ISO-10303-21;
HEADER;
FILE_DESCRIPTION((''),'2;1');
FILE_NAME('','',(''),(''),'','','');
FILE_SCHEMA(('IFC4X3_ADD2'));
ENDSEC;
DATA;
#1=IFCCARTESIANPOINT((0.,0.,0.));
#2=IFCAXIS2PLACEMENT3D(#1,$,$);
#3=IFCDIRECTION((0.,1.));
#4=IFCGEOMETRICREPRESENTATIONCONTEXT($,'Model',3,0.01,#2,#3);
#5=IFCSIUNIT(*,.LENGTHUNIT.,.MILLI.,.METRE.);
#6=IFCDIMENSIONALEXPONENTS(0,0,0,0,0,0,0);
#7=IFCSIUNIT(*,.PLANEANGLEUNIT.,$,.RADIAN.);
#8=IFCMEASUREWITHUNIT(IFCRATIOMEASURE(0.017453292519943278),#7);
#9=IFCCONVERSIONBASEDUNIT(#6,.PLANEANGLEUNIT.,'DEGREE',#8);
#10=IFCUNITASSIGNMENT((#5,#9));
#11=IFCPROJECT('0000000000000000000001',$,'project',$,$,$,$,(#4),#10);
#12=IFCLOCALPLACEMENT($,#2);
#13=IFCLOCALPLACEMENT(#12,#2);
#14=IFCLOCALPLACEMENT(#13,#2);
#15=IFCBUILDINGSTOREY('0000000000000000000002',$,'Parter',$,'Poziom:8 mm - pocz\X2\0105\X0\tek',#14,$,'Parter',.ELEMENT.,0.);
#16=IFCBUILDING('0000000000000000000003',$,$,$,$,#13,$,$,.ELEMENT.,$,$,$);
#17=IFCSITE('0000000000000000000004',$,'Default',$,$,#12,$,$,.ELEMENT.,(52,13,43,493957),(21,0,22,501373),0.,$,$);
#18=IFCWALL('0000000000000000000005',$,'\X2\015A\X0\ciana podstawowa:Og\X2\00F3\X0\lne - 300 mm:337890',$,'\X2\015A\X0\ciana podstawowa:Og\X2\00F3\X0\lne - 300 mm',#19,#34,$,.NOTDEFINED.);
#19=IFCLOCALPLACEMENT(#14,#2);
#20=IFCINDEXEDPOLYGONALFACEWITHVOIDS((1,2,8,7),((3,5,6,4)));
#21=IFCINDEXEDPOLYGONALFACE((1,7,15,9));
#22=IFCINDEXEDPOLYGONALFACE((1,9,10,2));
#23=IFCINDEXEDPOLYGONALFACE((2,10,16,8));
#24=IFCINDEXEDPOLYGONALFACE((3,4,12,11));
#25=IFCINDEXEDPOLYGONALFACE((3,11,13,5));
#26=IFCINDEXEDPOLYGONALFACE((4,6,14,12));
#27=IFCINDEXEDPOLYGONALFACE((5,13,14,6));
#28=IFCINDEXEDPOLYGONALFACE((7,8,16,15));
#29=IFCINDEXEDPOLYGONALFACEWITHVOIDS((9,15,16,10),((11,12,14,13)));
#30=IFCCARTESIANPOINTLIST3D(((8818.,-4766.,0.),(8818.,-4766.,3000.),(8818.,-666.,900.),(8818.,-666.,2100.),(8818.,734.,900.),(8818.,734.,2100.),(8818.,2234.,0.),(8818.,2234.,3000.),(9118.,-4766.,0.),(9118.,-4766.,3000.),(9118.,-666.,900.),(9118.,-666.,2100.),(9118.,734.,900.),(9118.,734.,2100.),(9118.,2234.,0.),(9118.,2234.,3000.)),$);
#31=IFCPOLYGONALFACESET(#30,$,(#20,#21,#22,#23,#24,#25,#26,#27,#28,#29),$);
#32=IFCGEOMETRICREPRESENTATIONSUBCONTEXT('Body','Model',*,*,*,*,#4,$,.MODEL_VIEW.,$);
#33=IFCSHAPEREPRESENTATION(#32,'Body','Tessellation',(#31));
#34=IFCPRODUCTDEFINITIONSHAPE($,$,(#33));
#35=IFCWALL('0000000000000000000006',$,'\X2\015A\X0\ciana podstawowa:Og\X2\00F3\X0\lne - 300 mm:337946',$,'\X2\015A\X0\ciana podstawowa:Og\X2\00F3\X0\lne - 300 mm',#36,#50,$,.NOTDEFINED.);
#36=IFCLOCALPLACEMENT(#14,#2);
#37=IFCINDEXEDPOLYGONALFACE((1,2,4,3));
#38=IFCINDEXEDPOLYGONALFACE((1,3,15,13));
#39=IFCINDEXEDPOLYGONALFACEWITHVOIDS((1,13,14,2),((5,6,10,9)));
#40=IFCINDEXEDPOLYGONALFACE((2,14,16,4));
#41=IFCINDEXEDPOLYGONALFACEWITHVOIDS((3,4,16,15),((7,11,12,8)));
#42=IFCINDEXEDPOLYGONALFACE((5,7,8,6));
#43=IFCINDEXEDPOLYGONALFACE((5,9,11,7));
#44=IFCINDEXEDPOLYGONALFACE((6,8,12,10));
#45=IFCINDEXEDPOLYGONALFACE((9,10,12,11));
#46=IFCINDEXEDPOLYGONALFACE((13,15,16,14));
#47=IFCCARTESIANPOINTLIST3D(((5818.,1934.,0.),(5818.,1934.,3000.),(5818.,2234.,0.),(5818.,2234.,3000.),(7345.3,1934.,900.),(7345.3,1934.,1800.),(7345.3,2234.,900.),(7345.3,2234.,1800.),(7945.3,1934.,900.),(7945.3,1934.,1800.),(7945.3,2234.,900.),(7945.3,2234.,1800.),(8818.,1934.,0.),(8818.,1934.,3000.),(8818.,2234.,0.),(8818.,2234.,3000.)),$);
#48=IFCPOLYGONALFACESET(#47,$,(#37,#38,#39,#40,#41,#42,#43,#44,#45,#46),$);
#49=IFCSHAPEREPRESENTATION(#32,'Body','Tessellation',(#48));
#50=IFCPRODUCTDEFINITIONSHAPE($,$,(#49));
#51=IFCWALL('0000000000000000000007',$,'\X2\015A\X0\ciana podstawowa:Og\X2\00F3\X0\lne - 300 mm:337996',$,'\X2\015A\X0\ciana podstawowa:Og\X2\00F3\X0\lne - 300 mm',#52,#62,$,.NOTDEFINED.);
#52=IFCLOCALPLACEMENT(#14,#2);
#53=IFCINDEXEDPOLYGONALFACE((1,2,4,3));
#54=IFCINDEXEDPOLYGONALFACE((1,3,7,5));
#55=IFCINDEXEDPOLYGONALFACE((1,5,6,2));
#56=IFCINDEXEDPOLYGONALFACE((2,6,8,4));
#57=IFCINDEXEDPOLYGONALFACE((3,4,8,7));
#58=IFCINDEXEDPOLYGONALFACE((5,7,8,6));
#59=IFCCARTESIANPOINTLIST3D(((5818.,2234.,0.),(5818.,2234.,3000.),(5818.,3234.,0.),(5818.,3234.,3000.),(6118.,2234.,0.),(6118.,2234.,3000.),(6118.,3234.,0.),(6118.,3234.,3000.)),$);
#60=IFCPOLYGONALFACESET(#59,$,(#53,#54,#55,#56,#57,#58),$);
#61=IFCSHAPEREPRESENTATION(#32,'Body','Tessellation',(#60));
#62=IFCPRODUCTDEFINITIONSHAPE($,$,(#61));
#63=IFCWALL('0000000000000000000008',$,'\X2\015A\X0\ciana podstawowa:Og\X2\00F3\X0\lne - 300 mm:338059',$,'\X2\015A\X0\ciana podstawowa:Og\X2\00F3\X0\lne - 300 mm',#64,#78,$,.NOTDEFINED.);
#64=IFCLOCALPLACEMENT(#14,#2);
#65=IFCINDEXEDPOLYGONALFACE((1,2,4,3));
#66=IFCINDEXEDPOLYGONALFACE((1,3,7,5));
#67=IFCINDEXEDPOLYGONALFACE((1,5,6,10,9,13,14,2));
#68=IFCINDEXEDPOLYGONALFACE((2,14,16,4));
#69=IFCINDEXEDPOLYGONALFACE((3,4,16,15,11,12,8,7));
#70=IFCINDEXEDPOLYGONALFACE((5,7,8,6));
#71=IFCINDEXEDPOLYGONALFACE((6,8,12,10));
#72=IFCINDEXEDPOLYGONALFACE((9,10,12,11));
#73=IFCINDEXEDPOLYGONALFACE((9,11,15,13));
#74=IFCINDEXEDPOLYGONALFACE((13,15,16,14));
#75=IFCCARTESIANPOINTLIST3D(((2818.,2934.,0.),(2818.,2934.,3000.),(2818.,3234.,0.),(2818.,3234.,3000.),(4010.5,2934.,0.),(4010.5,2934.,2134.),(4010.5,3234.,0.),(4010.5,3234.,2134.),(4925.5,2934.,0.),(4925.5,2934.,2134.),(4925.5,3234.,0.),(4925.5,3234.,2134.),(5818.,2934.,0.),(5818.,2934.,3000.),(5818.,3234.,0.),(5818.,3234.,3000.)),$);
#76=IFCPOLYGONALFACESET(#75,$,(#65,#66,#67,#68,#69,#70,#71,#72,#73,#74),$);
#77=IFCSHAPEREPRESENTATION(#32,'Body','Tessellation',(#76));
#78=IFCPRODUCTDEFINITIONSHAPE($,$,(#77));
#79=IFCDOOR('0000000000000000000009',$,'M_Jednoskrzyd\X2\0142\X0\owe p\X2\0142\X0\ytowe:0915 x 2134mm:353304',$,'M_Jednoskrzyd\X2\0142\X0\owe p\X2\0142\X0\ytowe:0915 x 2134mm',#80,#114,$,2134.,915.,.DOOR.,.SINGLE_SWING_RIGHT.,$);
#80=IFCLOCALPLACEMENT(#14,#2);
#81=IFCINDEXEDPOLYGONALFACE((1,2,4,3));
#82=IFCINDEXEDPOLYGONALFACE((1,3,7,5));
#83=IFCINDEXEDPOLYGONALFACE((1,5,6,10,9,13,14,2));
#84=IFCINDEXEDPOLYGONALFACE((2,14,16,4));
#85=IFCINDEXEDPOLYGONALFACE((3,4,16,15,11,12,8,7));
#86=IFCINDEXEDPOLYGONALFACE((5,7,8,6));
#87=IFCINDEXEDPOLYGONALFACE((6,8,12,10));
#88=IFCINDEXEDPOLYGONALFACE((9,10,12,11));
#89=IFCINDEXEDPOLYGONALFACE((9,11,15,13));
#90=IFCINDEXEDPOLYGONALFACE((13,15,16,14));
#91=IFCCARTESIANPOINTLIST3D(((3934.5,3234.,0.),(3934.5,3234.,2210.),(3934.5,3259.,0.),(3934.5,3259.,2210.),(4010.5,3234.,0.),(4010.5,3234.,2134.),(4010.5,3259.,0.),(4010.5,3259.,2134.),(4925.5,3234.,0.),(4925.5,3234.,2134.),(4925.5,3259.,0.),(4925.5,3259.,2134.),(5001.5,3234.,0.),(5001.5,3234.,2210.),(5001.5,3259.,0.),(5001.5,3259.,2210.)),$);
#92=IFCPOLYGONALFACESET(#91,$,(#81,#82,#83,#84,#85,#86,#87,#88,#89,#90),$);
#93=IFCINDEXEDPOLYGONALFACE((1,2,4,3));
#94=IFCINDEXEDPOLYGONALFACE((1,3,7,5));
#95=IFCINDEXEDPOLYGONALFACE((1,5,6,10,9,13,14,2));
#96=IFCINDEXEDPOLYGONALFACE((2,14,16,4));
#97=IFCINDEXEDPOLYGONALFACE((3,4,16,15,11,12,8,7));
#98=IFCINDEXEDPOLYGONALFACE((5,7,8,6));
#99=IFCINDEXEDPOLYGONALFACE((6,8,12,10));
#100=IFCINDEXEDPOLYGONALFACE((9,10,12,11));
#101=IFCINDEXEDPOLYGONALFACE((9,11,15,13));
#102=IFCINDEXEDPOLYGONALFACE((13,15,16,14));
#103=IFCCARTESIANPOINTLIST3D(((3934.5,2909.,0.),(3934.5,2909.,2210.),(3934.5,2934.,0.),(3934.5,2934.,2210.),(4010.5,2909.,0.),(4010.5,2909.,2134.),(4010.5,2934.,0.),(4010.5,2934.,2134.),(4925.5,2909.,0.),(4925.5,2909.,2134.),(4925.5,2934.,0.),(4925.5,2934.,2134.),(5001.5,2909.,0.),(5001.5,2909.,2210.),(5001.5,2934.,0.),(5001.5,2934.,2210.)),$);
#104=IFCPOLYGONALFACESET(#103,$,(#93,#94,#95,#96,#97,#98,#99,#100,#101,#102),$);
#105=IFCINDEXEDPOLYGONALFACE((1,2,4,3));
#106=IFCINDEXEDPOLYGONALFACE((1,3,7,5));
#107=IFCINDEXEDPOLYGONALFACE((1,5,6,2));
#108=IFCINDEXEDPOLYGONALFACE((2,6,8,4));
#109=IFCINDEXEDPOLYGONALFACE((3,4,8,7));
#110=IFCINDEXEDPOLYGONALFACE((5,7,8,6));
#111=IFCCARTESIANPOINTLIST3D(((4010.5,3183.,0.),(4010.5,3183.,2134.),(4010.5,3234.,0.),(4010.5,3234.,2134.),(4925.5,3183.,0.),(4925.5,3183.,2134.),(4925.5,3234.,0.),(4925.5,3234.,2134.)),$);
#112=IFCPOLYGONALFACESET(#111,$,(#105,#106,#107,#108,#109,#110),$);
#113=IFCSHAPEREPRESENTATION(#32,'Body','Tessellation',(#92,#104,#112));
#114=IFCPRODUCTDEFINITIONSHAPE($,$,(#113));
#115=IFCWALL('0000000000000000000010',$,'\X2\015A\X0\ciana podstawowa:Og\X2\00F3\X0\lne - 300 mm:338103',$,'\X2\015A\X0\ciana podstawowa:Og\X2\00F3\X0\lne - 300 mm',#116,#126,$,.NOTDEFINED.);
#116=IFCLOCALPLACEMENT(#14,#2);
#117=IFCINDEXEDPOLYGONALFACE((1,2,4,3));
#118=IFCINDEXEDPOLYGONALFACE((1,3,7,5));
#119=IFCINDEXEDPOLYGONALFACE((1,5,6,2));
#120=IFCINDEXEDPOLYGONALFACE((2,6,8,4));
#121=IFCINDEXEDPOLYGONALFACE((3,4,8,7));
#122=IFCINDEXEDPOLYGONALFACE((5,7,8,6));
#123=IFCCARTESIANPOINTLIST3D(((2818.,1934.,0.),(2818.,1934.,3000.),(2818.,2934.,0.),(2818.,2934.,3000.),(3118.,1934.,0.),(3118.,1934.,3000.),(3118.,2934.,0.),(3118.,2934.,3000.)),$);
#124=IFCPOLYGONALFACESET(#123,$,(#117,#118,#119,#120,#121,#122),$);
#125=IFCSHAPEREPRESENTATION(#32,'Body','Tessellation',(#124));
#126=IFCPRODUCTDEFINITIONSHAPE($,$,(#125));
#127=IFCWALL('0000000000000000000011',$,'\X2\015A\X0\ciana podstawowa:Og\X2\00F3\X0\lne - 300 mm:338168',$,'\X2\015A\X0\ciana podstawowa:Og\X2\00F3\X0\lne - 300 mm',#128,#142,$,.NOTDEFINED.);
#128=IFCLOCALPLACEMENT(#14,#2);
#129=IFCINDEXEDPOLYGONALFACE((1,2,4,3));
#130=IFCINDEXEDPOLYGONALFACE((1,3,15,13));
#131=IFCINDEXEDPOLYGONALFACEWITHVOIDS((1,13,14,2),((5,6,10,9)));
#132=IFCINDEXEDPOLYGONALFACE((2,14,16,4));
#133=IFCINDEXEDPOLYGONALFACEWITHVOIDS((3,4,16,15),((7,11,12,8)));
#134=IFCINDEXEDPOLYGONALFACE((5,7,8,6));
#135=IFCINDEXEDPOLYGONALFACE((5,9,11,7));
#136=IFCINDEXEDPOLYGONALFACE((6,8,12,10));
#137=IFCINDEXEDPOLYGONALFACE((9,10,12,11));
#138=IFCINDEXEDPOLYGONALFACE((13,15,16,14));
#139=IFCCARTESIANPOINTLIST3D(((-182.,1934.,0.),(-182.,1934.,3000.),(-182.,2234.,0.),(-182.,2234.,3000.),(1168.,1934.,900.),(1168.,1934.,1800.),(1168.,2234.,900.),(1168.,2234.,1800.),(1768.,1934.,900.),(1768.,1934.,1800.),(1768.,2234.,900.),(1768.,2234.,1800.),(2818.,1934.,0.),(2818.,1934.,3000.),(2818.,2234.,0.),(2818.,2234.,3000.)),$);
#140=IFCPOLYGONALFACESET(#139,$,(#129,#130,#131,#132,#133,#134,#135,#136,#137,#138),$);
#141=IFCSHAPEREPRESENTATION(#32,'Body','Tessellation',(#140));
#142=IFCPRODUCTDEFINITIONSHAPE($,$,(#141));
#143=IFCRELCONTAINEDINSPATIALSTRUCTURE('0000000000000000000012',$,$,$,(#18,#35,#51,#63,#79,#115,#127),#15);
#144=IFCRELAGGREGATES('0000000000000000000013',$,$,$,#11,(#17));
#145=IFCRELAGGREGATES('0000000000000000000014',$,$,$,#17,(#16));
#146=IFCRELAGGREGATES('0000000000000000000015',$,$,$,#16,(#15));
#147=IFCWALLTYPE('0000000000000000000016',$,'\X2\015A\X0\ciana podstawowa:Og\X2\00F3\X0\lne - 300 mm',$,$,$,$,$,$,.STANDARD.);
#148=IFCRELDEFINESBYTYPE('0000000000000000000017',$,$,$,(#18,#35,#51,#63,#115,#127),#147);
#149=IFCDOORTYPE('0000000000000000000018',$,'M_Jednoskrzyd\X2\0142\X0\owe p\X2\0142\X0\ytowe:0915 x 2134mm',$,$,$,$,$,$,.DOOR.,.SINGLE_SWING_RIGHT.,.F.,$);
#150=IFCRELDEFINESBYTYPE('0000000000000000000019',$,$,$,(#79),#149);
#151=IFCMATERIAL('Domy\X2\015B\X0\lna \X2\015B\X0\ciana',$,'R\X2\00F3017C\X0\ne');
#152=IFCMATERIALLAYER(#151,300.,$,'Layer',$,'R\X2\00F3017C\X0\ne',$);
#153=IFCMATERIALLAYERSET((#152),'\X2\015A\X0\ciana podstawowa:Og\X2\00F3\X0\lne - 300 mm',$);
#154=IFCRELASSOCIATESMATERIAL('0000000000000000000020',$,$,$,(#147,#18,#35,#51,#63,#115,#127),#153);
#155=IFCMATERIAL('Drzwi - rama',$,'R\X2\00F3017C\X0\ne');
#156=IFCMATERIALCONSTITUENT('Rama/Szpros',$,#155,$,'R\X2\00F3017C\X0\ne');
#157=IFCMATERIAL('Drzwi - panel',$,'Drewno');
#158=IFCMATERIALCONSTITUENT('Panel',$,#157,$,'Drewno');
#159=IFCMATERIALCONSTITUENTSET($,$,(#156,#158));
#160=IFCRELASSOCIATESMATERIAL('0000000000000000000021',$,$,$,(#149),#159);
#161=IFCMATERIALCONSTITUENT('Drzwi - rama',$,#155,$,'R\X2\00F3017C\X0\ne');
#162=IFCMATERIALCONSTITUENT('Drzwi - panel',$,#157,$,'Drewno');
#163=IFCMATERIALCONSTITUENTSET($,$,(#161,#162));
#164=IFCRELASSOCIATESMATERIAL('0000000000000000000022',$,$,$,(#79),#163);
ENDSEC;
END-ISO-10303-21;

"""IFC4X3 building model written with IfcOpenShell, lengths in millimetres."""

from ifc_helpers import new_model, entity, si_unit, converted_unit, direction, frame, frame_2d, origin, place, context, subcontext, project, spatial, polyline, rectangle, outline, extrude, source, transform, mapped, material, layer, layer_set, constituent, constituent_set, type_object, type_shapes, element, fill, save


model = new_model("IFC4X3")

# Units and contexts
model_context = context("Model", 3, precision=0.01, world=origin(), true_north=direction((0.0, 1.0)))
body_context = subcontext(model_context, "Body", "Model", "MODEL_VIEW")
ifc_project = project(units=[si_unit("LENGTHUNIT", "METRE", prefix="MILLI"), converted_unit("PLANEANGLEUNIT", "DEGREE", entity("IfcRatioMeasure", 0.017453292519943278), si_unit("PLANEANGLEUNIT", "RADIAN"), dimensions=[0, 0, 0, 0, 0, 0, 0])], contexts=[model_context])

# Site, building, storey
site_placement = place(None, origin())
site = spatial("IfcSite", under=ifc_project, at=site_placement, Name="Default", CompositionType="ELEMENT", RefLatitude=(52, 13, 43, 493957), RefLongitude=(21, 0, 22, 501373), RefElevation=0.0)
building_placement = place(site_placement, origin())
building = spatial("IfcBuilding", under=site, at=building_placement, CompositionType="ELEMENT")
storey_placement = place(building_placement, origin())
storey = spatial("IfcBuildingStorey", under=building, at=storey_placement, Name="Parter", ObjectType="Poziom:8 mm - początek", LongName="Parter", CompositionType="ELEMENT", Elevation=0.0)

# Walls, openings
ifc_material_1 = material(Name="Domyślna ściana", Category="Różne")
ifc_layer = layer(ifc_material_1, 300.0, Name="Layer", Category="Różne")
ifc_layer_set = layer_set([ifc_layer], Name="Ściana podstawowa:Ogólne - 300 mm")
wall_type = type_object("IfcWallType", Name="Ściana podstawowa:Ogólne - 300 mm", PredefinedType="STANDARD", material=ifc_layer_set)
wall_1_placement = place(storey_placement, frame((8968.0, -4766.0, 0.0), z_axis=(0.0, 0.0, 1.0), x_axis=(0.0, 1.0, 0.0)))
wall_1 = element("IfcWall", 1, at=wall_1_placement, inside=storey, type_object=wall_type, material=ifc_layer_set, Name="Ściana podstawowa:Ogólne - 300 mm:337890", ObjectType="Ściana podstawowa:Ogólne - 300 mm", PredefinedType="NOTDEFINED", context=body_context, shape_type="SweptSolid", body=[
    extrude(rectangle(XDim=7000.0, YDim=300.0, at=frame_2d((3500.0, 0.0), x_axis=(-1.0, 0.0))), origin(), (0.0, 0.0, 1.0), 3000.0),
])
opening_1_placement = place(wall_1_placement, frame((5500.0, 150.0, 900.0)))
element("IfcOpeningElement", 2, at=opening_1_placement, cuts=wall_1, PredefinedType="OPENING", context=body_context, shape_type="SweptSolid", body=[
    extrude(rectangle(XDim=1200.0, YDim=1400.0, at=frame_2d((600.0, 700.0), x_axis=(-1.0, 0.0))), frame((0.0, 0.0, 0.0), z_axis=(0.0, -1.0, 0.0), x_axis=(0.0, 0.0, 1.0)), (0.0, 0.0, 1.0), 300.0),
])
wall_2_placement = place(storey_placement, frame((8818.0, 2084.0, 0.0), z_axis=(0.0, 0.0, 1.0), x_axis=(-1.0, 0.0, 0.0)))
wall_2 = element("IfcWall", 3, at=wall_2_placement, inside=storey, type_object=wall_type, material=ifc_layer_set, Name="Ściana podstawowa:Ogólne - 300 mm:337946", ObjectType="Ściana podstawowa:Ogólne - 300 mm", PredefinedType="NOTDEFINED", context=body_context, shape_type="SweptSolid", body=[
    extrude(rectangle(XDim=3000.0, YDim=300.0, at=frame_2d((1500.0, 0.0), x_axis=(-1.0, 0.0))), origin(), (0.0, 0.0, 1.0), 3000.0),
])
opening_2_placement = place(wall_2_placement, frame((1472.7, 150.0, 900.0)))
element("IfcOpeningElement", 4, at=opening_2_placement, cuts=wall_2, PredefinedType="OPENING", context=body_context, shape_type="SweptSolid", body=[
    extrude(rectangle(XDim=900.0, YDim=600.0, at=frame_2d((450.0, 300.0), x_axis=(-1.0, 0.0))), frame((0.0, 0.0, 0.0), z_axis=(0.0, -1.0, 0.0), x_axis=(0.0, 0.0, 1.0)), (0.0, 0.0, 1.0), 300.0),
])

# Wall
wall_3_placement = place(storey_placement, frame((5968.0, 2234.0, 0.0), z_axis=(0.0, 0.0, 1.0), x_axis=(0.0, 1.0, 0.0)))
element("IfcWall", 5, at=wall_3_placement, inside=storey, type_object=wall_type, material=ifc_layer_set, Name="Ściana podstawowa:Ogólne - 300 mm:337996", ObjectType="Ściana podstawowa:Ogólne - 300 mm", PredefinedType="NOTDEFINED", context=body_context, shape_type="SweptSolid", body=[
    extrude(rectangle(XDim=1000.0, YDim=300.0, at=frame_2d((500.0, 0.0), x_axis=(-1.0, 0.0))), origin(), (0.0, 0.0, 1.0), 3000.0),
])

# Wall, opening, door
wall_4_placement = place(storey_placement, frame((5818.0, 3084.0, 0.0), z_axis=(0.0, 0.0, 1.0), x_axis=(-1.0, 0.0, 0.0)))
wall_4 = element("IfcWall", 6, at=wall_4_placement, inside=storey, type_object=wall_type, material=ifc_layer_set, Name="Ściana podstawowa:Ogólne - 300 mm:338059", ObjectType="Ściana podstawowa:Ogólne - 300 mm", PredefinedType="NOTDEFINED", context=body_context, shape_type="SweptSolid", body=[
    extrude(rectangle(XDim=3000.0, YDim=300.0, at=frame_2d((1500.0, 0.0), x_axis=(1.0, 0.0))), origin(), (0.0, 0.0, 1.0), 3000.0),
])
opening_3_placement = place(wall_4_placement, frame((1807.5, 150.0, 0.0)))
opening_3 = element("IfcOpeningElement", 7, at=opening_3_placement, cuts=wall_4, PredefinedType="OPENING", context=body_context, shape_type="SweptSolid", body=[
    extrude(rectangle(XDim=915.0, YDim=2134.0, at=frame_2d((1067.0, 457.5), x_axis=(0.0, 1.0))), frame((0.0, 0.0, 0.0), z_axis=(0.0, -1.0, 0.0), x_axis=(0.0, 0.0, 1.0)), (0.0, 0.0, 1.0), 300.0),
])
ifc_material_2 = material(Name="Drzwi - rama", Category="Różne")
ifc_constituent_1 = constituent(ifc_material_2, Name="Drzwi - rama", Category="Różne")
ifc_material_3 = material(Name="Drzwi - panel", Category="Drewno")
ifc_constituent_2 = constituent(ifc_material_3, Name="Drzwi - panel", Category="Drewno")
ifc_constituent_set_1 = constituent_set(constituents=[ifc_constituent_1, ifc_constituent_2])
ifc_constituent_3 = constituent(ifc_material_2, Name="Rama/Szpros", Category="Różne")
ifc_constituent_4 = constituent(ifc_material_3, Name="Panel", Category="Drewno")
ifc_constituent_set_2 = constituent_set(constituents=[ifc_constituent_3, ifc_constituent_4])
door_type = type_object("IfcDoorType", Name="M_Jednoskrzydłowe płytowe:0915 x 2134mm", OperationType="SINGLE_SWING_RIGHT", ParameterTakesPrecedence=False, PredefinedType="DOOR", material=ifc_constituent_set_2)
shared_shape_1 = source(origin(), body_context, "Body", "SweptSolid", [
    extrude(outline(polyline([(-533.5, -1124.0), (533.5, -1124.0), (533.5, 1086.0), (457.5, 1086.0), (457.5, -1048.0), (-457.5, -1048.0), (-457.5, 1086.0), (-533.5, 1086.0), (-533.5, -1124.0)])), frame((457.5, 300.0, 1086.0), z_axis=(0.0, 1.0, 0.0), x_axis=(1.0, 0.0, 0.0)), (0.0, 0.0, 1.0), 25.0),
    extrude(outline(polyline([(-1124.0, -533.5), (1086.0, -533.5), (1086.0, -457.5), (-1048.0, -457.5), (-1048.0, 457.5), (1086.0, 457.5), (1086.0, 533.5), (-1124.0, 533.5), (-1124.0, -533.5)])), frame((457.5, -25.0, 1086.0), z_axis=(0.0, 1.0, 0.0), x_axis=(0.0, 0.0, -1.0)), (0.0, 0.0, 1.0), 25.0),
    extrude(rectangle(XDim=51.0, YDim=915.0, at=frame_2d((0.0, 0.0), x_axis=(1.0, 0.0))), frame((457.5, 274.5, 0.0), z_axis=(0.0, 0.0, 1.0), x_axis=(0.0, 1.0, 0.0)), (0.0, 0.0, 1.0), 2134.0),
])
type_shapes(door_type, [shared_shape_1])
door_placement = place(opening_3_placement, frame((0.0, 0.0, 0.0), z_axis=(0.0, 0.0, 1.0), x_axis=(-1.0, 0.0, 0.0)))
door = element("IfcDoor", 8, at=door_placement, inside=storey, type_object=door_type, material=ifc_constituent_set_1, Name="M_Jednoskrzydłowe płytowe:0915 x 2134mm:353304", ObjectType="M_Jednoskrzydłowe płytowe:0915 x 2134mm", OperationType="SINGLE_SWING_RIGHT", OverallHeight=2134.0, OverallWidth=915.0, PredefinedType="DOOR", context=body_context, shape_type="MappedRepresentation", body=[
    mapped(shared_shape_1, transform((0.0, 0.0, 0.0), scale=1.0)),
])
fill(opening_3, door)

# Wall
wall_5_placement = place(storey_placement, frame((2968.0, 2934.0, 0.0), z_axis=(0.0, 0.0, 1.0), x_axis=(0.0, -1.0, 0.0)))
element("IfcWall", 9, at=wall_5_placement, inside=storey, type_object=wall_type, material=ifc_layer_set, Name="Ściana podstawowa:Ogólne - 300 mm:338103", ObjectType="Ściana podstawowa:Ogólne - 300 mm", PredefinedType="NOTDEFINED", context=body_context, shape_type="SweptSolid", body=[
    extrude(rectangle(XDim=1000.0, YDim=300.0, at=frame_2d((500.0, 0.0), x_axis=(-1.0, 0.0))), origin(), (0.0, 0.0, 1.0), 3000.0),
])

# Wall, opening
wall_6_placement = place(storey_placement, frame((2818.0, 2084.0, 0.0), z_axis=(0.0, 0.0, 1.0), x_axis=(-1.0, 0.0, 0.0)))
wall_6 = element("IfcWall", 10, at=wall_6_placement, inside=storey, type_object=wall_type, material=ifc_layer_set, Name="Ściana podstawowa:Ogólne - 300 mm:338168", ObjectType="Ściana podstawowa:Ogólne - 300 mm", PredefinedType="NOTDEFINED", context=body_context, shape_type="SweptSolid", body=[
    extrude(rectangle(XDim=3000.0, YDim=300.0, at=frame_2d((1500.0, 0.0), x_axis=(-1.0, 0.0))), origin(), (0.0, 0.0, 1.0), 3000.0),
])
opening_4_placement = place(wall_6_placement, frame((1650.0, 150.0, 900.0)))
element("IfcOpeningElement", 11, at=opening_4_placement, cuts=wall_6, PredefinedType="OPENING", context=body_context, shape_type="SweptSolid", body=[
    extrude(rectangle(XDim=900.0, YDim=600.0, at=frame_2d((450.0, 300.0), x_axis=(-1.0, 0.0))), frame((0.0, 0.0, 0.0), z_axis=(0.0, -1.0, 0.0), x_axis=(0.0, 0.0, 1.0)), (0.0, 0.0, 1.0), 300.0),
])

save(model, "model.ifc")
